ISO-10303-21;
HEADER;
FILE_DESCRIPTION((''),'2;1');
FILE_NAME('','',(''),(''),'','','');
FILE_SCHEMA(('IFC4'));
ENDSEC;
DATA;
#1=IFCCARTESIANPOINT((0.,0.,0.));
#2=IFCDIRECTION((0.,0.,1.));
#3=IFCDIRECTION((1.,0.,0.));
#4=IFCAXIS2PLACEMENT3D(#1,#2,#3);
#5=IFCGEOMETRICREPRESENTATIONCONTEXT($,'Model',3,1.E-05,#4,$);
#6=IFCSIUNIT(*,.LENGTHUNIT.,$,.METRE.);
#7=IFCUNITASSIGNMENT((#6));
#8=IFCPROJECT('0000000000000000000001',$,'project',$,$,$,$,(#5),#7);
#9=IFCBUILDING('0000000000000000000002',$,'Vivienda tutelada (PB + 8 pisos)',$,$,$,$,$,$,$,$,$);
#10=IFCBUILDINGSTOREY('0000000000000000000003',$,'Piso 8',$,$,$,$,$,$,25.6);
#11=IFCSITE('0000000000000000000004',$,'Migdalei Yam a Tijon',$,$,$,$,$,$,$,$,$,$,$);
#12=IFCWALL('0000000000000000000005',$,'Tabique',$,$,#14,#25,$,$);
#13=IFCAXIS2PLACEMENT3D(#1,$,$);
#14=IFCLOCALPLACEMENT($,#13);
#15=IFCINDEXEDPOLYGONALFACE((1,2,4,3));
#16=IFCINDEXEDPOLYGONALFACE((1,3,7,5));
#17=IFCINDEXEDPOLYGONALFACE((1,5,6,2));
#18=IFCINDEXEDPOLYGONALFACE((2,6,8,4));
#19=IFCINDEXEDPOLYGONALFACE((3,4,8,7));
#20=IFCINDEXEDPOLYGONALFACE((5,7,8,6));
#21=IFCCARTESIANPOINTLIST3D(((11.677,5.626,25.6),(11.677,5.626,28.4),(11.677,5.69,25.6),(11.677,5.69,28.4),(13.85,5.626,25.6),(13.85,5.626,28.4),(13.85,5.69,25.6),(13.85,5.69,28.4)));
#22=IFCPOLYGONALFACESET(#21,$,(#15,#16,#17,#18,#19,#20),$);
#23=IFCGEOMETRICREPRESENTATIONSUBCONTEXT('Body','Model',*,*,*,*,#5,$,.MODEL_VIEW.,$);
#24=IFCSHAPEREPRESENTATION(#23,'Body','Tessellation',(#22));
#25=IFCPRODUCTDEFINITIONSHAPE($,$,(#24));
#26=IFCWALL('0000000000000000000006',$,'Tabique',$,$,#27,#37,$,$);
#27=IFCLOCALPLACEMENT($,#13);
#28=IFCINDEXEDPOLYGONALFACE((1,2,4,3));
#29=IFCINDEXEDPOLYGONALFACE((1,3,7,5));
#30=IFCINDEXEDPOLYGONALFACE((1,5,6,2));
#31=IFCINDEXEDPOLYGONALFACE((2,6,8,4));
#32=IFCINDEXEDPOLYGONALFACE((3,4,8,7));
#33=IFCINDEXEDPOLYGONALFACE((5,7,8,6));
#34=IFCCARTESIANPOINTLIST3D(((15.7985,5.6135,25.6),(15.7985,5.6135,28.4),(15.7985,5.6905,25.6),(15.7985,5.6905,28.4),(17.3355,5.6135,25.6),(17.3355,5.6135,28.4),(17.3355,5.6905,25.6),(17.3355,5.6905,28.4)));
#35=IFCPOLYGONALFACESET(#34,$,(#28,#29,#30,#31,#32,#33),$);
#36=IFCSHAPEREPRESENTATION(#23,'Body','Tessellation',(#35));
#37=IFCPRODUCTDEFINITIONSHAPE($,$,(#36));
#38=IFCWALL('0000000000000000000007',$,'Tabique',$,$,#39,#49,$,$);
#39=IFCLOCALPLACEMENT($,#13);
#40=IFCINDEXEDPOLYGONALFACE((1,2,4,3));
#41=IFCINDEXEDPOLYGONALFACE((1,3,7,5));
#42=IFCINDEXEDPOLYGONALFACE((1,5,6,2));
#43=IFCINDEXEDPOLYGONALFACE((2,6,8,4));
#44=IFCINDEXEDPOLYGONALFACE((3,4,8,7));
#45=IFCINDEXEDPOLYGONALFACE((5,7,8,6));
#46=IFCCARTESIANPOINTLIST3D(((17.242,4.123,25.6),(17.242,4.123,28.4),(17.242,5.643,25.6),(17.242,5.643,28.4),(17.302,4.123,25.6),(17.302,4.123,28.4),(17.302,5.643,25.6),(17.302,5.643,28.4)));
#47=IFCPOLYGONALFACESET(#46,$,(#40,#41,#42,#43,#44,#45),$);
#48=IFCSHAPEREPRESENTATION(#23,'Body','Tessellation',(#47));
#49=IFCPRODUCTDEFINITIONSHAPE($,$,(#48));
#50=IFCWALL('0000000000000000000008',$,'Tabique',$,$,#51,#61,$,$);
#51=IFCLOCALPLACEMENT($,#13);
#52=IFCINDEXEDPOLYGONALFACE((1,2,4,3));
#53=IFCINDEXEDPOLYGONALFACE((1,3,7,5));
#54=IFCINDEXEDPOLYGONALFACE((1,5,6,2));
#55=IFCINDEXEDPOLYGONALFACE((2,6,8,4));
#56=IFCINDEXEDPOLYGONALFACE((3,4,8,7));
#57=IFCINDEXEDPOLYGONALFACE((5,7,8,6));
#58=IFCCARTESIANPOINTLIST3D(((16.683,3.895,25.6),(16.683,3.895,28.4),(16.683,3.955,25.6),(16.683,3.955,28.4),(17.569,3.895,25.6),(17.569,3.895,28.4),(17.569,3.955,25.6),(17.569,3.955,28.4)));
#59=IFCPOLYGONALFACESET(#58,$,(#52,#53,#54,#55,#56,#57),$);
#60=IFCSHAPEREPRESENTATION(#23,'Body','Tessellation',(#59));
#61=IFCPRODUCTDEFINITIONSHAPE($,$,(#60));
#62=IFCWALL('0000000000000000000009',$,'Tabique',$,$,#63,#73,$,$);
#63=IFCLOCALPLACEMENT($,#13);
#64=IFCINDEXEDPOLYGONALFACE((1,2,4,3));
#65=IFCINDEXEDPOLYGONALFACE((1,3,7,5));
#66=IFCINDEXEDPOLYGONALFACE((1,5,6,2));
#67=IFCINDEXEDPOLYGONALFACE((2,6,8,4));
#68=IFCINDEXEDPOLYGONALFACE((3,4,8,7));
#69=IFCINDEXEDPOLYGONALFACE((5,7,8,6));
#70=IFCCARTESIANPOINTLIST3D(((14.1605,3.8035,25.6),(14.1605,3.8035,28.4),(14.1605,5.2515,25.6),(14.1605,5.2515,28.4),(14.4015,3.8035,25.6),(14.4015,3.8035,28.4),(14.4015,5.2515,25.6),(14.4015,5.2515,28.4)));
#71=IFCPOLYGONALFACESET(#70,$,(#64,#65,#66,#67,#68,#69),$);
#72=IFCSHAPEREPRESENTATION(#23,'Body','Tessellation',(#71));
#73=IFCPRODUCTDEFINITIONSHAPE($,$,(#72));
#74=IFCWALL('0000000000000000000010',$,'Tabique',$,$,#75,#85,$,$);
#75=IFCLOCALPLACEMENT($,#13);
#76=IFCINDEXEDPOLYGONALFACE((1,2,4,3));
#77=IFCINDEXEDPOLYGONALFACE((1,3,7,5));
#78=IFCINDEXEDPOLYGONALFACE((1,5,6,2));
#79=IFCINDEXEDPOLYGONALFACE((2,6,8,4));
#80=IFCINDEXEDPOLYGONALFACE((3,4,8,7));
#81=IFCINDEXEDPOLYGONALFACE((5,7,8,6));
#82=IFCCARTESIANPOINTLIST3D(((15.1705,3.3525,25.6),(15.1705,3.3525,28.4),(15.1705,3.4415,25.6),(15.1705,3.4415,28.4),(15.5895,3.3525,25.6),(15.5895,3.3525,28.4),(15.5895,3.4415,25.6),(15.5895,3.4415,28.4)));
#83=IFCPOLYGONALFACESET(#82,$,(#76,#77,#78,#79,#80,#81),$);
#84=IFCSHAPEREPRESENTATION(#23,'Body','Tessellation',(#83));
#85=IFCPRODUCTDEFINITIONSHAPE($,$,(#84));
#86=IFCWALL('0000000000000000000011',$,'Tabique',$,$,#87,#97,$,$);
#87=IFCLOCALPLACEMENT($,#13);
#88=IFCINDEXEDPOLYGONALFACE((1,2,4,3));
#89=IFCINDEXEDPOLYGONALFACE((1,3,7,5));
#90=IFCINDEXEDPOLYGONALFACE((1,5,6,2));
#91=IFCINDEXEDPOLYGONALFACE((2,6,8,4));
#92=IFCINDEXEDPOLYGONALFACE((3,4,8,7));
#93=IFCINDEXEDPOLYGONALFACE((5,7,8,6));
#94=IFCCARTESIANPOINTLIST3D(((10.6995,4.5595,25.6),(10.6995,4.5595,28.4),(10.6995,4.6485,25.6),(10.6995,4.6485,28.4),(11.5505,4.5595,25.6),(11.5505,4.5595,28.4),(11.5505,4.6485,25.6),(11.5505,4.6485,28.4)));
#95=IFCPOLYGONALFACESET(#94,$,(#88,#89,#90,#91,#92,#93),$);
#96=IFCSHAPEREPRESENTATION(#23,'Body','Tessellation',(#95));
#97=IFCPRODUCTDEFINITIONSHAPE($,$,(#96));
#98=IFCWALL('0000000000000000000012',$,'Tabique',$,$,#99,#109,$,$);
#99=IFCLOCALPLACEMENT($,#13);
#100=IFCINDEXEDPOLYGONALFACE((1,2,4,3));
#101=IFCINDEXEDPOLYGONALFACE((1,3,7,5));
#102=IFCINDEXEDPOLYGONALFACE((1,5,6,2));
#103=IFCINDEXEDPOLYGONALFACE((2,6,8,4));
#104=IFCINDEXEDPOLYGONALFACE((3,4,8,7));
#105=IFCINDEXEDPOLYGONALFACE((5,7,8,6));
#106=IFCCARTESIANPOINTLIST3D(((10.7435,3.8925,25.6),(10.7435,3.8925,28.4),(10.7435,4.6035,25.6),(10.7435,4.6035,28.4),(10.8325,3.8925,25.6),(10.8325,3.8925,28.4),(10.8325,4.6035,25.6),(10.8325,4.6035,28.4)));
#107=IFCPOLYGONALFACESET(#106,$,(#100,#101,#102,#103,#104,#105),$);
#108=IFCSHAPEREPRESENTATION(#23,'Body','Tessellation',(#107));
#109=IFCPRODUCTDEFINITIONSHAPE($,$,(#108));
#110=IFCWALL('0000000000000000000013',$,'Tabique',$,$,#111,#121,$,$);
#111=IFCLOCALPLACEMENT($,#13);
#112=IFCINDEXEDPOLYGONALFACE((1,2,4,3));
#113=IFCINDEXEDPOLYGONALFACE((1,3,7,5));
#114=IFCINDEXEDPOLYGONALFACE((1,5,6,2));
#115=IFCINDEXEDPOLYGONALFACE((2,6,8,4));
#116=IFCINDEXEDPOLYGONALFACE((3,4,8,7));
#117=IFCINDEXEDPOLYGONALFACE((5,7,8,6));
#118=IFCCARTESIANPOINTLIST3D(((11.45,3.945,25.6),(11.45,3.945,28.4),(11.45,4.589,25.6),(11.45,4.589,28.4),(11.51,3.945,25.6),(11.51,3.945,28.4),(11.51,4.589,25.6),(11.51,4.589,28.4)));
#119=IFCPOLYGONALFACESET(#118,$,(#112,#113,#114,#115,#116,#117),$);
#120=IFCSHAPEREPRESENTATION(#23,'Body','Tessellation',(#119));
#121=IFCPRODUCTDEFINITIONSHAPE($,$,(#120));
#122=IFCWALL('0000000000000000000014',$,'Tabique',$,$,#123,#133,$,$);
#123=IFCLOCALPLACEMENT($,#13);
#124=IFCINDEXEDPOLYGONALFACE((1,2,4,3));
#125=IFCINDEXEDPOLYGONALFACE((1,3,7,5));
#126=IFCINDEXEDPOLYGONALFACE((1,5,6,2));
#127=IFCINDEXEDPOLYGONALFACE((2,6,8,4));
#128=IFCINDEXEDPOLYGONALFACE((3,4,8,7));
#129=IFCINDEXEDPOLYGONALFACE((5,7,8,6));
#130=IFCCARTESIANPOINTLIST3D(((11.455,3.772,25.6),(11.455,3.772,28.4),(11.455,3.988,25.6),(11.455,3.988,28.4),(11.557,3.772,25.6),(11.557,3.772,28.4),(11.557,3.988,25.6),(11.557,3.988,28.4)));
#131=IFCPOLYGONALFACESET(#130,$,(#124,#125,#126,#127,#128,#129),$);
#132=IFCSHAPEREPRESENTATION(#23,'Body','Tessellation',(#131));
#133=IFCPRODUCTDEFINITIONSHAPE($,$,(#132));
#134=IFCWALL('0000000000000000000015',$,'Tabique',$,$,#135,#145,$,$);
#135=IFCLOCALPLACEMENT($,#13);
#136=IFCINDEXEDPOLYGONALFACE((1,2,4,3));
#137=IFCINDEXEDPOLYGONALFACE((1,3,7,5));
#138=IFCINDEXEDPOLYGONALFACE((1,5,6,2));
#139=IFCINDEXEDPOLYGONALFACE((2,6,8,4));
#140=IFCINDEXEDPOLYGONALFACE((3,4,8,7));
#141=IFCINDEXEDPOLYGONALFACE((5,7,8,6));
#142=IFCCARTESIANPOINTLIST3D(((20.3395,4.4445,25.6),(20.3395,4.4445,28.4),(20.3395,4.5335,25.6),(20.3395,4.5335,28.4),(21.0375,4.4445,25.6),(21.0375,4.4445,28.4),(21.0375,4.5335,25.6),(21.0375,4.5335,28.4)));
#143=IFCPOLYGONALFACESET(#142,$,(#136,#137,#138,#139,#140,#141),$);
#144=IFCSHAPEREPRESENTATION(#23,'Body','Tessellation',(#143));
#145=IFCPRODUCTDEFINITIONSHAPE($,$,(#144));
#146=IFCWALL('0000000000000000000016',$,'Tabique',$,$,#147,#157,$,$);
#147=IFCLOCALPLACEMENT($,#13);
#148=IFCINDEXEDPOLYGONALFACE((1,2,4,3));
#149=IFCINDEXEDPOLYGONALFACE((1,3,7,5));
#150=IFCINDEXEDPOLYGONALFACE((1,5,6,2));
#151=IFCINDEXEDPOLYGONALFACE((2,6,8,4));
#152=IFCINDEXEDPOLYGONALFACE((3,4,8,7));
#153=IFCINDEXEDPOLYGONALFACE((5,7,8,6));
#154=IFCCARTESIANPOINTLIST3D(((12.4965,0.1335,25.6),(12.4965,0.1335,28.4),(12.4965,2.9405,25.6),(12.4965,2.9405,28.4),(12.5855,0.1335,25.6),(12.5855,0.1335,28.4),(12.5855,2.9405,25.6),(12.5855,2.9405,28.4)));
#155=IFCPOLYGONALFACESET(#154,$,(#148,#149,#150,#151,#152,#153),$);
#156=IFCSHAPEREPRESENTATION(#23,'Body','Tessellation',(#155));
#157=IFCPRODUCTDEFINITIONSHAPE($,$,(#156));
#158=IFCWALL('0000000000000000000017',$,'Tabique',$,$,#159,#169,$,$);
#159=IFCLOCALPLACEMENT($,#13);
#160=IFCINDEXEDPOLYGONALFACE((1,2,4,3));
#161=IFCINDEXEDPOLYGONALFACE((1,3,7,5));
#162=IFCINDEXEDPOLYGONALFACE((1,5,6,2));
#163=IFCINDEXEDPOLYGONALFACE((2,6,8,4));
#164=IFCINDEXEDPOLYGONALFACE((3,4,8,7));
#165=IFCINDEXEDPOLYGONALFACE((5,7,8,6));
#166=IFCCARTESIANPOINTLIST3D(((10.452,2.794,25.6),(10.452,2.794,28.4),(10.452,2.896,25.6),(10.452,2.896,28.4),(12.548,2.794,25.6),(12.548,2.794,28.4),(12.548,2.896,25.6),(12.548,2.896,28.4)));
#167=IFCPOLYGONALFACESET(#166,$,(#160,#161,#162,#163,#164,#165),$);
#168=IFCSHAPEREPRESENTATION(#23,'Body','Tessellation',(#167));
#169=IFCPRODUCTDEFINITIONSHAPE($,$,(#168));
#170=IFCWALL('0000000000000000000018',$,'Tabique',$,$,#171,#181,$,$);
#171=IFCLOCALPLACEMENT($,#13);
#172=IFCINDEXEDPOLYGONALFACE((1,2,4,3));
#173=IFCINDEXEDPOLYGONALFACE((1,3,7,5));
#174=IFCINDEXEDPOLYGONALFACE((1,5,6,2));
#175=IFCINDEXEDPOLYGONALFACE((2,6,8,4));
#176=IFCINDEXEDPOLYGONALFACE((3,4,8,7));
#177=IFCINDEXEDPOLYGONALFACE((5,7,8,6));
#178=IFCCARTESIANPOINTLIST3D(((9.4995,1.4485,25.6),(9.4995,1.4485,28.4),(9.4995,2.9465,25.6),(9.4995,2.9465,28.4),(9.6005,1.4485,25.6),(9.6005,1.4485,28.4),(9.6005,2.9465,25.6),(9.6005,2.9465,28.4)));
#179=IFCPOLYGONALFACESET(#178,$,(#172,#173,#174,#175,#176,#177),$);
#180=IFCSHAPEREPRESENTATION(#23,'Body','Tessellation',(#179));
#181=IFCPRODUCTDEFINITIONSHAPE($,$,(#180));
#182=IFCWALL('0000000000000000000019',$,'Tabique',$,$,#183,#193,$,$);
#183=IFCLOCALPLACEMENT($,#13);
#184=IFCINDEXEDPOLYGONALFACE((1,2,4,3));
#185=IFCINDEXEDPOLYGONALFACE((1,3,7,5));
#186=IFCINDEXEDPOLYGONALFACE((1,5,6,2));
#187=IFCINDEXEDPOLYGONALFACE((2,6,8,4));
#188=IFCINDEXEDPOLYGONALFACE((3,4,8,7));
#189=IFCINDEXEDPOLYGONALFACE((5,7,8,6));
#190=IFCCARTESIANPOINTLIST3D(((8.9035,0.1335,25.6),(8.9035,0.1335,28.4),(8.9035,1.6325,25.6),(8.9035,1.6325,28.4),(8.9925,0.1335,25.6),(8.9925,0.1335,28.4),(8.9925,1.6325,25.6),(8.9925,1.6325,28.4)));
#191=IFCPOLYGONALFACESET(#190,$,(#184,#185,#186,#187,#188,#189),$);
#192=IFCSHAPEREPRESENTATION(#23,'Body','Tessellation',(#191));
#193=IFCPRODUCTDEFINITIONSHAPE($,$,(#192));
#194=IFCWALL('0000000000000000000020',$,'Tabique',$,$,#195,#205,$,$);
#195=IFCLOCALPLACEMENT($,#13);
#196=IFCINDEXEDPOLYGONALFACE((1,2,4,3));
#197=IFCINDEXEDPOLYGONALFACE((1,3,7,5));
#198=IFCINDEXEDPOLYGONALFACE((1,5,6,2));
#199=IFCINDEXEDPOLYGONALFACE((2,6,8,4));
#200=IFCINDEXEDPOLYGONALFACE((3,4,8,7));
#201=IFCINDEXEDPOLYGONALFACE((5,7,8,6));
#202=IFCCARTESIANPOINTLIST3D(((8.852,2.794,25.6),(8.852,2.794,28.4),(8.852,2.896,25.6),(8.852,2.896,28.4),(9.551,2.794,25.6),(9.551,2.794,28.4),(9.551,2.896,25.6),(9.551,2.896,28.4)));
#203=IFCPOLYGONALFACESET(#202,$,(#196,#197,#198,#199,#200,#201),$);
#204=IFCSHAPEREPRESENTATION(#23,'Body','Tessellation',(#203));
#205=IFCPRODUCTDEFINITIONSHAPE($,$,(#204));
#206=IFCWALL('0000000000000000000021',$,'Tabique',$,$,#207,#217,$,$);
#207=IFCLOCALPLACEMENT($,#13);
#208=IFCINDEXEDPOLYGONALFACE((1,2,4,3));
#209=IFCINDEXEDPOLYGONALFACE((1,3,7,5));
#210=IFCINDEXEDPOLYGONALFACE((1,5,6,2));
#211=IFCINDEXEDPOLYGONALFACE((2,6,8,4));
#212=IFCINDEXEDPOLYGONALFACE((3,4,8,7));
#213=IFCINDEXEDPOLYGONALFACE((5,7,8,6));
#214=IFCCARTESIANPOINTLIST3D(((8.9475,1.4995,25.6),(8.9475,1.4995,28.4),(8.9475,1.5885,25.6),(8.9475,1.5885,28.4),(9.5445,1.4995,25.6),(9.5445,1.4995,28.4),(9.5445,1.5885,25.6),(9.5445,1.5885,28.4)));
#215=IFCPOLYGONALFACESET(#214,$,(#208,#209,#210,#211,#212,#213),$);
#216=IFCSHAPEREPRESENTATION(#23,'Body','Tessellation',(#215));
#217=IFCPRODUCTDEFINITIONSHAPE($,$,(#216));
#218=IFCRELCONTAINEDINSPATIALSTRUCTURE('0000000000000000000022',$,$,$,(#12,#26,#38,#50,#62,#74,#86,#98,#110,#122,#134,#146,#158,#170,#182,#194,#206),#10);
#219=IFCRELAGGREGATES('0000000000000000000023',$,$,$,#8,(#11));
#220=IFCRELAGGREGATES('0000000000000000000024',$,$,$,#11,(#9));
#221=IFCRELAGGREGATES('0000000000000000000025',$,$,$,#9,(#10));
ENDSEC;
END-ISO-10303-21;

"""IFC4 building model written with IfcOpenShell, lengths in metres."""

from ifc_helpers import new_model, si_unit, frame, origin_with_axes, context, subcontext, project, spatial, line, indexed_curve, outline, extrude, element, save


model = new_model("IFC4")

# Units and contexts
model_context = context("Model", 3, precision=1e-05, world=origin_with_axes())
body_context = subcontext(model_context, "Body", "Model", "MODEL_VIEW")
ifc_project = project(units=[si_unit("LENGTHUNIT", "METRE")], contexts=[model_context])

# Site, building, storey
site = spatial("IfcSite", under=ifc_project, Name="Migdalei Yam a Tijon")
building = spatial("IfcBuilding", under=site, Name="Vivienda tutelada (PB + 8 pisos)")
storey = spatial("IfcBuildingStorey", under=building, Name="Piso 8", Elevation=25.6)

# Walls
element("IfcWall", 1, inside=storey, Name="Tabique", context=body_context, shape_type="SweptSolid", body=[
    extrude(outline(indexed_curve([(0.0, 0.0), (2.173, 0.0), (2.173, 0.064), (0.0, 0.064)], segments=[line(1, 2, 3, 4, 1)])), frame((11.677, 5.626, 25.6), z_axis=(0.0, 0.0, 1.0), x_axis=(1.0, 0.0, 0.0)), (0.0, 0.0, 1.0), 2.8),
])
element("IfcWall", 2, inside=storey, Name="Tabique", context=body_context, shape_type="SweptSolid", body=[
    extrude(outline(indexed_curve([(0.0, 0.0), (1.537, 0.0), (1.537, 0.077), (0.0, 0.077)], segments=[line(1, 2, 3, 4, 1)])), frame((15.7985, 5.6135, 25.6), z_axis=(0.0, 0.0, 1.0), x_axis=(1.0, 0.0, 0.0)), (0.0, 0.0, 1.0), 2.8),
])
element("IfcWall", 3, inside=storey, Name="Tabique", context=body_context, shape_type="SweptSolid", body=[
    extrude(outline(indexed_curve([(0.0, 0.0), (0.06, 0.0), (0.06, 1.52), (0.0, 1.52)], segments=[line(1, 2, 3, 4, 1)])), frame((17.242, 4.123, 25.6), z_axis=(0.0, 0.0, 1.0), x_axis=(1.0, 0.0, 0.0)), (0.0, 0.0, 1.0), 2.8),
])
element("IfcWall", 4, inside=storey, Name="Tabique", context=body_context, shape_type="SweptSolid", body=[
    extrude(outline(indexed_curve([(0.0, 0.0), (0.886, 0.0), (0.886, 0.06), (0.0, 0.06)], segments=[line(1, 2, 3, 4, 1)])), frame((16.683, 3.895, 25.6), z_axis=(0.0, 0.0, 1.0), x_axis=(1.0, 0.0, 0.0)), (0.0, 0.0, 1.0), 2.8),
])
element("IfcWall", 5, inside=storey, Name="Tabique", context=body_context, shape_type="SweptSolid", body=[
    extrude(outline(indexed_curve([(0.0, 0.0), (0.241, 0.0), (0.241, 1.448), (0.0, 1.448)], segments=[line(1, 2, 3, 4, 1)])), frame((14.1605, 3.8035, 25.6), z_axis=(0.0, 0.0, 1.0), x_axis=(1.0, 0.0, 0.0)), (0.0, 0.0, 1.0), 2.8),
])
element("IfcWall", 6, inside=storey, Name="Tabique", context=body_context, shape_type="SweptSolid", body=[
    extrude(outline(indexed_curve([(0.0, 0.0), (0.419, 0.0), (0.419, 0.089), (0.0, 0.089)], segments=[line(1, 2, 3, 4, 1)])), frame((15.1705, 3.3525, 25.6), z_axis=(0.0, 0.0, 1.0), x_axis=(1.0, 0.0, 0.0)), (0.0, 0.0, 1.0), 2.8),
])
element("IfcWall", 7, inside=storey, Name="Tabique", context=body_context, shape_type="SweptSolid", body=[
    extrude(outline(indexed_curve([(0.0, 0.0), (0.851, 0.0), (0.851, 0.089), (0.0, 0.089)], segments=[line(1, 2, 3, 4, 1)])), frame((10.6995, 4.5595, 25.6), z_axis=(0.0, 0.0, 1.0), x_axis=(1.0, 0.0, 0.0)), (0.0, 0.0, 1.0), 2.8),
])
element("IfcWall", 8, inside=storey, Name="Tabique", context=body_context, shape_type="SweptSolid", body=[
    extrude(outline(indexed_curve([(0.0, 0.0), (0.089, 0.0), (0.089, 0.711), (0.0, 0.711)], segments=[line(1, 2, 3, 4, 1)])), frame((10.7435, 3.8925, 25.6), z_axis=(0.0, 0.0, 1.0), x_axis=(1.0, 0.0, 0.0)), (0.0, 0.0, 1.0), 2.8),
])
element("IfcWall", 9, inside=storey, Name="Tabique", context=body_context, shape_type="SweptSolid", body=[
    extrude(outline(indexed_curve([(0.0, 0.0), (0.06, 0.0), (0.06, 0.644), (0.0, 0.644)], segments=[line(1, 2, 3, 4, 1)])), frame((11.45, 3.945, 25.6), z_axis=(0.0, 0.0, 1.0), x_axis=(1.0, 0.0, 0.0)), (0.0, 0.0, 1.0), 2.8),
])
element("IfcWall", 10, inside=storey, Name="Tabique", context=body_context, shape_type="SweptSolid", body=[
    extrude(outline(indexed_curve([(0.0, 0.0), (0.102, 0.0), (0.102, 0.216), (0.0, 0.216)], segments=[line(1, 2, 3, 4, 1)])), frame((11.455, 3.772, 25.6), z_axis=(0.0, 0.0, 1.0), x_axis=(1.0, 0.0, 0.0)), (0.0, 0.0, 1.0), 2.8),
])
element("IfcWall", 11, inside=storey, Name="Tabique", context=body_context, shape_type="SweptSolid", body=[
    extrude(outline(indexed_curve([(0.0, 0.0), (0.698, 0.0), (0.698, 0.089), (0.0, 0.089)], segments=[line(1, 2, 3, 4, 1)])), frame((20.3395, 4.4445, 25.6), z_axis=(0.0, 0.0, 1.0), x_axis=(1.0, 0.0, 0.0)), (0.0, 0.0, 1.0), 2.8),
])
element("IfcWall", 12, inside=storey, Name="Tabique", context=body_context, shape_type="SweptSolid", body=[
    extrude(outline(indexed_curve([(0.0, 0.0), (0.089, 0.0), (0.089, 2.807), (0.0, 2.807)], segments=[line(1, 2, 3, 4, 1)])), frame((12.4965, 0.1335, 25.6), z_axis=(0.0, 0.0, 1.0), x_axis=(1.0, 0.0, 0.0)), (0.0, 0.0, 1.0), 2.8),
])
element("IfcWall", 13, inside=storey, Name="Tabique", context=body_context, shape_type="SweptSolid", body=[
    extrude(outline(indexed_curve([(0.0, 0.0), (2.096, 0.0), (2.096, 0.102), (0.0, 0.102)], segments=[line(1, 2, 3, 4, 1)])), frame((10.452, 2.794, 25.6), z_axis=(0.0, 0.0, 1.0), x_axis=(1.0, 0.0, 0.0)), (0.0, 0.0, 1.0), 2.8),
])
element("IfcWall", 14, inside=storey, Name="Tabique", context=body_context, shape_type="SweptSolid", body=[
    extrude(outline(indexed_curve([(0.0, 0.0), (0.101, 0.0), (0.101, 1.498), (0.0, 1.498)], segments=[line(1, 2, 3, 4, 1)])), frame((9.4995, 1.4485, 25.6), z_axis=(0.0, 0.0, 1.0), x_axis=(1.0, 0.0, 0.0)), (0.0, 0.0, 1.0), 2.8),
])
element("IfcWall", 15, inside=storey, Name="Tabique", context=body_context, shape_type="SweptSolid", body=[
    extrude(outline(indexed_curve([(0.0, 0.0), (0.089, 0.0), (0.089, 1.499), (0.0, 1.499)], segments=[line(1, 2, 3, 4, 1)])), frame((8.9035, 0.1335, 25.6), z_axis=(0.0, 0.0, 1.0), x_axis=(1.0, 0.0, 0.0)), (0.0, 0.0, 1.0), 2.8),
])
element("IfcWall", 16, inside=storey, Name="Tabique", context=body_context, shape_type="SweptSolid", body=[
    extrude(outline(indexed_curve([(0.0, 0.0), (0.699, 0.0), (0.699, 0.102), (0.0, 0.102)], segments=[line(1, 2, 3, 4, 1)])), frame((8.852, 2.794, 25.6), z_axis=(0.0, 0.0, 1.0), x_axis=(1.0, 0.0, 0.0)), (0.0, 0.0, 1.0), 2.8),
])
element("IfcWall", 17, inside=storey, Name="Tabique", context=body_context, shape_type="SweptSolid", body=[
    extrude(outline(indexed_curve([(0.0, 0.0), (0.597, 0.0), (0.597, 0.089), (0.0, 0.089)], segments=[line(1, 2, 3, 4, 1)])), frame((8.9475, 1.4995, 25.6), z_axis=(0.0, 0.0, 1.0), x_axis=(1.0, 0.0, 0.0)), (0.0, 0.0, 1.0), 2.8),
])

save(model, "model.ifc")
